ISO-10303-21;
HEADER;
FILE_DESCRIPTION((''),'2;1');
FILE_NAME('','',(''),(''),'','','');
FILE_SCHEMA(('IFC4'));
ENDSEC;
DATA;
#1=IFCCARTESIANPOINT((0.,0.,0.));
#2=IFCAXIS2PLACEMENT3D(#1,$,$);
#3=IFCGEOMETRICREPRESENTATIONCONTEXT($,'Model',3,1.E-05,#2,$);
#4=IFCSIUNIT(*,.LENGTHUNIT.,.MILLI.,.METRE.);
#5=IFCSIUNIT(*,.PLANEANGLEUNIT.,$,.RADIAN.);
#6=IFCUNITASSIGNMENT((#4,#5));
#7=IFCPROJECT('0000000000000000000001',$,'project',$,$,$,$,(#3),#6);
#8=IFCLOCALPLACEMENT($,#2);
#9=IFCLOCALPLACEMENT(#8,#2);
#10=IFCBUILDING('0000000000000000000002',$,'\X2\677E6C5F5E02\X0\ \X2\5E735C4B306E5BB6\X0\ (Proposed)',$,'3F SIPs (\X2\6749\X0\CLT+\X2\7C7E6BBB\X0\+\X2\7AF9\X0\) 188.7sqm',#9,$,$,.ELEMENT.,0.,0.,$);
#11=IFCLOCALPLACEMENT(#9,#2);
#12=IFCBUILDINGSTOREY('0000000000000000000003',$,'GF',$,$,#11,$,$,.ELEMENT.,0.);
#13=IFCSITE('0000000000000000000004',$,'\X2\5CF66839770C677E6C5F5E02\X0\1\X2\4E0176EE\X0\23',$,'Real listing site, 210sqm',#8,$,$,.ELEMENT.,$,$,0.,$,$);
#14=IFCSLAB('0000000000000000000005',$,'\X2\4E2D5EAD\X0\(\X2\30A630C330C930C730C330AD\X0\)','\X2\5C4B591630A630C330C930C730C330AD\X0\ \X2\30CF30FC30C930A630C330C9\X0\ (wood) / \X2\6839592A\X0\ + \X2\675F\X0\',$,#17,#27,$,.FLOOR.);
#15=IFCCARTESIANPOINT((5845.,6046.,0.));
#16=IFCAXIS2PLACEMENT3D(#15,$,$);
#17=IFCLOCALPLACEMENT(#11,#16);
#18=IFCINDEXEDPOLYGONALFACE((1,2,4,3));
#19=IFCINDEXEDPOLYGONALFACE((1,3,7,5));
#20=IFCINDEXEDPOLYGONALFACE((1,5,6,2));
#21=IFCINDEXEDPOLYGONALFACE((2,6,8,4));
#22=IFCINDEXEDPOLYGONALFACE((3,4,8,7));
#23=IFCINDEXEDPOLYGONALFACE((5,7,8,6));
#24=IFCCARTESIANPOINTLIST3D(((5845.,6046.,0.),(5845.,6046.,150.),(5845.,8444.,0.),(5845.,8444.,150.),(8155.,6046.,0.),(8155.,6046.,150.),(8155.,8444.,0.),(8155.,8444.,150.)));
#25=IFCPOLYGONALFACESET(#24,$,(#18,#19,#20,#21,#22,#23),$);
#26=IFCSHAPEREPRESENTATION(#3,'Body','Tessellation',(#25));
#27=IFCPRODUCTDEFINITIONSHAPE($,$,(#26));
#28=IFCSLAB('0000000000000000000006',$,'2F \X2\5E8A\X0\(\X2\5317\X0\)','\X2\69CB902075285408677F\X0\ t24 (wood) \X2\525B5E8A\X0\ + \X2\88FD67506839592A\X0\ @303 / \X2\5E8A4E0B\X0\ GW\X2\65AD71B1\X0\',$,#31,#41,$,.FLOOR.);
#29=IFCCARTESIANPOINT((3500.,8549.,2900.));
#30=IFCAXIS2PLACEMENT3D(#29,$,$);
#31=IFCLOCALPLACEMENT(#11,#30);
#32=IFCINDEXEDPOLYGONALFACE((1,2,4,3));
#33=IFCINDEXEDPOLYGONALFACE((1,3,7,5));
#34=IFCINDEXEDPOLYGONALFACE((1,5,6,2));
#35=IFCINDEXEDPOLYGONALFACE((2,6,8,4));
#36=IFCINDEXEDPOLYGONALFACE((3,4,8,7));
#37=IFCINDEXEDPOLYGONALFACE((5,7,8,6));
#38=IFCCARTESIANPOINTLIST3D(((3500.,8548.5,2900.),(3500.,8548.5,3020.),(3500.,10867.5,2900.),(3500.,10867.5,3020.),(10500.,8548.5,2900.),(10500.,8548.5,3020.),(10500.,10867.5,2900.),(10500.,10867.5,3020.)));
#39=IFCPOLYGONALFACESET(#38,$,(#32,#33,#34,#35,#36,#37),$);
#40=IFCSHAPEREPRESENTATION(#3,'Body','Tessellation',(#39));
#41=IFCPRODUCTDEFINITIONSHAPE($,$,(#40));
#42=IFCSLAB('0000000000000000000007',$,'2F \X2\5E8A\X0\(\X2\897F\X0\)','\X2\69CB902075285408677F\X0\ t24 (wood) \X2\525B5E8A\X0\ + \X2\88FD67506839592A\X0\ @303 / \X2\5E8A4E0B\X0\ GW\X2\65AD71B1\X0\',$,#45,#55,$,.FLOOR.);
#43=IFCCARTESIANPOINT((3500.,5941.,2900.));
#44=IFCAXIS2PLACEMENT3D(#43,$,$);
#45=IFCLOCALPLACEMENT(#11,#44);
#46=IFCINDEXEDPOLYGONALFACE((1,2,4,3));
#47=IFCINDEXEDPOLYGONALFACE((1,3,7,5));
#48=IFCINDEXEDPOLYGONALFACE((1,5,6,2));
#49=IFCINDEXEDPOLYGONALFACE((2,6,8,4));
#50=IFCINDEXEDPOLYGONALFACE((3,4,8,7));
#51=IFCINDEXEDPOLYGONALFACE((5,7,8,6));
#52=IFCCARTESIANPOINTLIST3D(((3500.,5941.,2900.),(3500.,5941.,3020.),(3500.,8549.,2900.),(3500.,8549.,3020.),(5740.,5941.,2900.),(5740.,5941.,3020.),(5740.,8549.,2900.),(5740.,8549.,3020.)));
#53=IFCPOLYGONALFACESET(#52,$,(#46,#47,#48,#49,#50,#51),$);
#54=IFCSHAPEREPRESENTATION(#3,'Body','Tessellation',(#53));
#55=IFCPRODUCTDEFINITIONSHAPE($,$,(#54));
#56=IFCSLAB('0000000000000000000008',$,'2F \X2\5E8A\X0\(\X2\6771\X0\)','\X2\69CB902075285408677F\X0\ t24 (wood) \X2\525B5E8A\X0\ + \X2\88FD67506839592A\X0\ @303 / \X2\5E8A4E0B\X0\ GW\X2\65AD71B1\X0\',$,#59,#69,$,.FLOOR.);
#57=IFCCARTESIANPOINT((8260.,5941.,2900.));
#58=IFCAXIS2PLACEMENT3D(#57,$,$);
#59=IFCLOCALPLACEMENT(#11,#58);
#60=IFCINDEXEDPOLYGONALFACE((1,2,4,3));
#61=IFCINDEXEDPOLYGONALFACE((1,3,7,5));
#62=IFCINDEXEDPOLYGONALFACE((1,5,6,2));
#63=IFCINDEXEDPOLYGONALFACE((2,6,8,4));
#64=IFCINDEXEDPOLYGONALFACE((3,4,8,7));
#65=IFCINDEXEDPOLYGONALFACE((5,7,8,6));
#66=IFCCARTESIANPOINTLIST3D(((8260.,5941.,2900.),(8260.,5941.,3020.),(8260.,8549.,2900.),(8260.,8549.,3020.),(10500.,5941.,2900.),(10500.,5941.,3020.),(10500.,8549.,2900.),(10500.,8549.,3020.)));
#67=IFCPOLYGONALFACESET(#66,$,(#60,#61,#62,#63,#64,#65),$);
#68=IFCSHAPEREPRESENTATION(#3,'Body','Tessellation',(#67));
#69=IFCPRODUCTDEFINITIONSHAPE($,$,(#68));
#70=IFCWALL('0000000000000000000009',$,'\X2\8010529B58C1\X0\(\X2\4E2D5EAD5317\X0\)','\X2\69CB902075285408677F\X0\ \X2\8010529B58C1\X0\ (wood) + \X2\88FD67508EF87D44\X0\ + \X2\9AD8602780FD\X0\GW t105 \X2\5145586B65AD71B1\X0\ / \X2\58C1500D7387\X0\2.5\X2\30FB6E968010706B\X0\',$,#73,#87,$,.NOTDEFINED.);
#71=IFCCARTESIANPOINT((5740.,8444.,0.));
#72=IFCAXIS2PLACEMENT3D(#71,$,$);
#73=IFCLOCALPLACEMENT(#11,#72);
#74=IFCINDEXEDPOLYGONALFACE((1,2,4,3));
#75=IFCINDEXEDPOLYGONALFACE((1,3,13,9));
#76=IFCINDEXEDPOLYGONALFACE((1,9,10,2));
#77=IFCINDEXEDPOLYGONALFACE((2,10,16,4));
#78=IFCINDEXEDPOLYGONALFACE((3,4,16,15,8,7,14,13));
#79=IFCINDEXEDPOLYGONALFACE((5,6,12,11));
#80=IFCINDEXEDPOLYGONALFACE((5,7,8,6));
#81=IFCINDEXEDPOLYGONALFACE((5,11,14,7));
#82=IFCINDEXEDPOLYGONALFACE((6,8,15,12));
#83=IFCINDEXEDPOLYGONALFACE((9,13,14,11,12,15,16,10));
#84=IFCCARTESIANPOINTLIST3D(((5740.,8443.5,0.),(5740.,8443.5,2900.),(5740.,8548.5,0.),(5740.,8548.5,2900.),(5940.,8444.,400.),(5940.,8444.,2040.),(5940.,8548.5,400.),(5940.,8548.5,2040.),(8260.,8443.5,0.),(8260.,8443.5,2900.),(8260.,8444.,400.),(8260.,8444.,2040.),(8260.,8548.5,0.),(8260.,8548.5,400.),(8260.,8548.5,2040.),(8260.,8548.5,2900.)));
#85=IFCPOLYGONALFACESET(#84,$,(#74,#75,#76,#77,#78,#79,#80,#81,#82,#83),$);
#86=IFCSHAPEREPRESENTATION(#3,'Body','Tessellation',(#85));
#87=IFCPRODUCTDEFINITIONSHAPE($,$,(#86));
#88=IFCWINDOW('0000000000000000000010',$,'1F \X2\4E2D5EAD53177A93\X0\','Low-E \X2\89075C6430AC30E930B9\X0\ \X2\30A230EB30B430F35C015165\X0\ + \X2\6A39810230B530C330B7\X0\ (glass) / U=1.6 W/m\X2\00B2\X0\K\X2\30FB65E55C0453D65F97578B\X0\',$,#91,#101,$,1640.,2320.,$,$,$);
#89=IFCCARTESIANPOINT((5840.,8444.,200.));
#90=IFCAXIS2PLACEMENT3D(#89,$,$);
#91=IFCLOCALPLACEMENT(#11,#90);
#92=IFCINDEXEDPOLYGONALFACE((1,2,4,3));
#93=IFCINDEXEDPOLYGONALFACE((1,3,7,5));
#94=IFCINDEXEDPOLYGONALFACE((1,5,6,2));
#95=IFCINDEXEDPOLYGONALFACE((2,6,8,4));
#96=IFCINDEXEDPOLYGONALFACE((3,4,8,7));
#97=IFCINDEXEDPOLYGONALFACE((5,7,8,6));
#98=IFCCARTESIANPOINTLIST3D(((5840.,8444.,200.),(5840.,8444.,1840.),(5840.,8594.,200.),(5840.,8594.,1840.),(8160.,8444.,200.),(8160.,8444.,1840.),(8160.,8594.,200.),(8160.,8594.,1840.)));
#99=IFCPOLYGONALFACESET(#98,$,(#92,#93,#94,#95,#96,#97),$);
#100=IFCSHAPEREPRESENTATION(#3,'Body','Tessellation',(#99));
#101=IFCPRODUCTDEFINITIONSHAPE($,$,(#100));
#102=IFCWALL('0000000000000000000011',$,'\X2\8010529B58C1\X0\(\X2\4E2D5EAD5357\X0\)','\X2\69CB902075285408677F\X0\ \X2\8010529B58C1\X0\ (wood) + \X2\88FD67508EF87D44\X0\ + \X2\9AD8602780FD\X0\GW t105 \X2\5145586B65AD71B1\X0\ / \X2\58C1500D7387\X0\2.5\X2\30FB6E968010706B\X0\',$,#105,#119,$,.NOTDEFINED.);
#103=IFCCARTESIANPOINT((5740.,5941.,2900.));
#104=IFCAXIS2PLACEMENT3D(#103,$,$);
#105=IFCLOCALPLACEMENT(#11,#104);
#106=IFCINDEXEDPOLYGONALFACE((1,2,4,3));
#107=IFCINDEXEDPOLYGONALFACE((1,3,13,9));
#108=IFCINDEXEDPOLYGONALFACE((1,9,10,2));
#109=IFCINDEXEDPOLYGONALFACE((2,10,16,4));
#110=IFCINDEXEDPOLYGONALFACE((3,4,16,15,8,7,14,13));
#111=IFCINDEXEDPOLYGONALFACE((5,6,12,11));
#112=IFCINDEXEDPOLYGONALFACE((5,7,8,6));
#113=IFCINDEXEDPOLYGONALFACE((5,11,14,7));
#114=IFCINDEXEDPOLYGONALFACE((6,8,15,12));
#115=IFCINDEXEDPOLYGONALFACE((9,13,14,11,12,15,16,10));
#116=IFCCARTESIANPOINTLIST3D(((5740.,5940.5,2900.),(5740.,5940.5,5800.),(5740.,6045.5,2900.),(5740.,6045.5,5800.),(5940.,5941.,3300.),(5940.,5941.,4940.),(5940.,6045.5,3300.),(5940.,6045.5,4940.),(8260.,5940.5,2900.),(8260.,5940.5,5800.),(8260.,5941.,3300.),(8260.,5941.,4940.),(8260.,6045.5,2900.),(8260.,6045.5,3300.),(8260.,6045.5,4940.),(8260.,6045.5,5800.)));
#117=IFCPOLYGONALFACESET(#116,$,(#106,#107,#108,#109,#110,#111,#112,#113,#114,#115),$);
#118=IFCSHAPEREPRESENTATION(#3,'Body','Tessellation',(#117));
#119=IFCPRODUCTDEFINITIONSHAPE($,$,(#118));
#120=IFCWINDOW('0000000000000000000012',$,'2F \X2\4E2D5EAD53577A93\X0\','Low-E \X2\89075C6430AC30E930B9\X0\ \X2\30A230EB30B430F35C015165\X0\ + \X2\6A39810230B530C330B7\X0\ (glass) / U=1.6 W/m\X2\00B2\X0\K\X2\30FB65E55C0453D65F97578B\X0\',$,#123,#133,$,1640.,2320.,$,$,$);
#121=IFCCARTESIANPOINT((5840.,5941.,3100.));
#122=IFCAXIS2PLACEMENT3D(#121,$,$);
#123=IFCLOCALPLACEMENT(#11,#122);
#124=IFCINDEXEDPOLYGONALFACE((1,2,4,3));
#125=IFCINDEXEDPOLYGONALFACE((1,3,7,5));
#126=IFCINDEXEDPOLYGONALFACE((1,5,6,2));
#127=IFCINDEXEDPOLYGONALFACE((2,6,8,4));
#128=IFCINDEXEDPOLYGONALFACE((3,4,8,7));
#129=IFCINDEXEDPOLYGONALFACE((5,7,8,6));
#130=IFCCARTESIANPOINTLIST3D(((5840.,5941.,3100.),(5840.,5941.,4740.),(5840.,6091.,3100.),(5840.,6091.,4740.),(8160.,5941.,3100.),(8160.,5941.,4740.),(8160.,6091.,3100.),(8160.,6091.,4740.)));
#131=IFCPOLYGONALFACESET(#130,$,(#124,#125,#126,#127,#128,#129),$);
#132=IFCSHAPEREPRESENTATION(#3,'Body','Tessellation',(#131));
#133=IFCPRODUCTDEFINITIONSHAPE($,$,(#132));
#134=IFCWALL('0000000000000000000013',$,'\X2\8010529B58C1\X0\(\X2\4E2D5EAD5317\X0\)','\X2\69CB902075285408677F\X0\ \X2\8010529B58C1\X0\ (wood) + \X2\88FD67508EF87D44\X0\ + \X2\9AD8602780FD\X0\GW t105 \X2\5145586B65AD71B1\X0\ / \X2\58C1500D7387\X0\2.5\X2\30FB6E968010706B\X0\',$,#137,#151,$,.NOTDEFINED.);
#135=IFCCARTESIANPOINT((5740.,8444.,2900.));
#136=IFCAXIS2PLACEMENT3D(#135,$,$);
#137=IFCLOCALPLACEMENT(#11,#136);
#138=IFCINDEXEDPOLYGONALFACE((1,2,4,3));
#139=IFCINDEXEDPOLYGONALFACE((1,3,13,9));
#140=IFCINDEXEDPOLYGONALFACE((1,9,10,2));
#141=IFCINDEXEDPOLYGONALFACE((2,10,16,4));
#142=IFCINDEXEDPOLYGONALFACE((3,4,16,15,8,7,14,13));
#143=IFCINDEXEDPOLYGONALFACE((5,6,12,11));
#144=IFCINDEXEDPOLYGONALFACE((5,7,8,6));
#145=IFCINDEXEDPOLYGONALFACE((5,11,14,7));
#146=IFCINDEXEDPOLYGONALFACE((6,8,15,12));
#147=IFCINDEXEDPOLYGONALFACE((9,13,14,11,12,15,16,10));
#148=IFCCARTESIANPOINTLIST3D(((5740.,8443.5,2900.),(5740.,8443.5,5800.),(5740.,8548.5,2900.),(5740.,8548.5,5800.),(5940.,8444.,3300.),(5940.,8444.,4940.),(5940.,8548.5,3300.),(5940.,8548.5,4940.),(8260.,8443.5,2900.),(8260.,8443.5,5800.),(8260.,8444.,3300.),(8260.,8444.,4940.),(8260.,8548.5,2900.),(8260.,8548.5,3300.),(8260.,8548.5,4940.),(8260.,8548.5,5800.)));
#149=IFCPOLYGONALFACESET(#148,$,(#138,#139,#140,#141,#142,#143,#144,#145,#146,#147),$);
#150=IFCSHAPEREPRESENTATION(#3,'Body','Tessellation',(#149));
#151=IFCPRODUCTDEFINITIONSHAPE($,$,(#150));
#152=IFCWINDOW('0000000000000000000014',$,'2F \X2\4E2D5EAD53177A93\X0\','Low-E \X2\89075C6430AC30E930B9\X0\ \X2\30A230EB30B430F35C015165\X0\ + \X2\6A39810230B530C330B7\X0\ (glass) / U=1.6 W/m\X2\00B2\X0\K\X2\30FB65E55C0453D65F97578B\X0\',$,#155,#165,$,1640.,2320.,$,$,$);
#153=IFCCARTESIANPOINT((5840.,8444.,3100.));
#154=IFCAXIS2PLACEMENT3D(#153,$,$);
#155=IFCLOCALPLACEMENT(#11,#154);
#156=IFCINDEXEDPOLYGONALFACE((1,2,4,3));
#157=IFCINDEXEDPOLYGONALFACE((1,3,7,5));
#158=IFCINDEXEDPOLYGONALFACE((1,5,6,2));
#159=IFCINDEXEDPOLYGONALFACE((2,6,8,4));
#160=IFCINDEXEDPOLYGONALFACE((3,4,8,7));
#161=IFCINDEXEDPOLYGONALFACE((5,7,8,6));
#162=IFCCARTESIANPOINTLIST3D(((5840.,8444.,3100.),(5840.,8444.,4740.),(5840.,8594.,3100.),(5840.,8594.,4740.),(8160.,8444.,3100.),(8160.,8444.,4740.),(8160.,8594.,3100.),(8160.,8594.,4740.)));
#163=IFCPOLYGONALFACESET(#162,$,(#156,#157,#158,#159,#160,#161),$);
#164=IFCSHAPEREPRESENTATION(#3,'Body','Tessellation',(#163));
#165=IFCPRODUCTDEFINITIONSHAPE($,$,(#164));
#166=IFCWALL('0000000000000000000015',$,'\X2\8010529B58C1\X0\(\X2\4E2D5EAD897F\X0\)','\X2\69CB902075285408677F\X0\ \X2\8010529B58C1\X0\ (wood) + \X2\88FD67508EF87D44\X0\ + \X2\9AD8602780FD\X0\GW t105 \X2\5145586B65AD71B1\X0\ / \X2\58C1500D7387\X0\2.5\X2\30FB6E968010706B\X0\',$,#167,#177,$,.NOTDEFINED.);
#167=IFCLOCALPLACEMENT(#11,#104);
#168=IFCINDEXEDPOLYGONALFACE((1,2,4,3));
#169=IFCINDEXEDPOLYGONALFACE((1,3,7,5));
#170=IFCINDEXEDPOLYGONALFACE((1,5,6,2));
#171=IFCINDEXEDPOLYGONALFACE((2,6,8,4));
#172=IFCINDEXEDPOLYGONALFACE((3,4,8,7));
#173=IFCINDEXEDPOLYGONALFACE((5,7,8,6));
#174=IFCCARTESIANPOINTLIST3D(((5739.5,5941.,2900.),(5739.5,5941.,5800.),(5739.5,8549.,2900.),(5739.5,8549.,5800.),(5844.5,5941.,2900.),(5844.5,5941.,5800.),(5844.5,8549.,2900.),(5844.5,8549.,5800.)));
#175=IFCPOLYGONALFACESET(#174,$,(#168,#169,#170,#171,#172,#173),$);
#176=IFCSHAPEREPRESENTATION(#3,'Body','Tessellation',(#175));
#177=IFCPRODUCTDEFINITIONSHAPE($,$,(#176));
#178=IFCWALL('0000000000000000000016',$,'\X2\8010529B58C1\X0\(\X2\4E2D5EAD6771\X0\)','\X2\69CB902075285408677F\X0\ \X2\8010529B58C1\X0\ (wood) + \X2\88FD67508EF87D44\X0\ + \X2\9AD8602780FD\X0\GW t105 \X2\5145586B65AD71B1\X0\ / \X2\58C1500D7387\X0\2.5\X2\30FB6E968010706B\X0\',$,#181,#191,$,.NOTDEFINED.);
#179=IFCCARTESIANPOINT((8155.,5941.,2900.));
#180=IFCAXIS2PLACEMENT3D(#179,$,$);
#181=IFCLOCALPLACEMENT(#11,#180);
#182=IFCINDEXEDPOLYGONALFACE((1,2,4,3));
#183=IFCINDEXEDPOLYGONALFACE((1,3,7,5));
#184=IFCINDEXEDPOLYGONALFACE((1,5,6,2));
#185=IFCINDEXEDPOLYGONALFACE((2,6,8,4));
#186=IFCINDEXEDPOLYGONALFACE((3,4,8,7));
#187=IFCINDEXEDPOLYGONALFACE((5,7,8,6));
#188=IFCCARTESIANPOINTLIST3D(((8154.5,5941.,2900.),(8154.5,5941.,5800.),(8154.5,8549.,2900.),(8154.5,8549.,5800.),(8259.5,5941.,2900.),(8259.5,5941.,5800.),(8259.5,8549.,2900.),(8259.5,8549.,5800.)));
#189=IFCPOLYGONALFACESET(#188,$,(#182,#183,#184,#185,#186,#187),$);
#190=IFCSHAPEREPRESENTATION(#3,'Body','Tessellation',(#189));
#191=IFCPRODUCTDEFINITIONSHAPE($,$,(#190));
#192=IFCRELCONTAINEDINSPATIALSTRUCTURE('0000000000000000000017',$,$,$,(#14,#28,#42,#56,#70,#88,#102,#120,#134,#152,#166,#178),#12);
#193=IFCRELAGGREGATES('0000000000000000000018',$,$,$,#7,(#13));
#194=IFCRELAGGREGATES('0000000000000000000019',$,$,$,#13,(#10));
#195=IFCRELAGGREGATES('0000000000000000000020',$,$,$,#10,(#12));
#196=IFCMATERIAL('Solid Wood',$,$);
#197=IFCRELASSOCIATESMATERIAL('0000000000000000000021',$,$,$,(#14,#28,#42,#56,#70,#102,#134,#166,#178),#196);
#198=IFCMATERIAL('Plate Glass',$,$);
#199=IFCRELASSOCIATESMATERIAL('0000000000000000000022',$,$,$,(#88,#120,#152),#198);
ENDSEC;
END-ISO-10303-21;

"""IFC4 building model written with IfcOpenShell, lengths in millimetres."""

from ifc_helpers import new_model, si_unit, frame, frame_2d, origin, place, context, project, spatial, rectangle, extrude, material, element, fill, save


model = new_model("IFC4")

# Units and contexts
model_context = context("Model", 3, precision=1e-05, world=origin())
ifc_project = project(units=[si_unit("LENGTHUNIT", "METRE", prefix="MILLI"), si_unit("PLANEANGLEUNIT", "RADIAN")], contexts=[model_context])

# Site, building, storey
site_placement = place(None, origin())
site = spatial("IfcSite", under=ifc_project, at=site_placement, Name="島根県松江市1丁目23", ObjectType="Real listing site, 210sqm", CompositionType="ELEMENT", RefElevation=0.0)
building_placement = place(site_placement, origin())
building = spatial("IfcBuilding", under=site, at=building_placement, Name="松江市 平屋の家 (Proposed)", ObjectType="3F SIPs (杉CLT+籾殻+竹) 188.7sqm", CompositionType="ELEMENT", ElevationOfRefHeight=0.0, ElevationOfTerrain=0.0)
storey_placement = place(building_placement, origin())
storey = spatial("IfcBuildingStorey", under=building, at=storey_placement, Name="GF", CompositionType="ELEMENT", Elevation=0.0)

# Slabs
ifc_material_1 = material(Name="Solid Wood")
slab_1_placement = place(storey_placement, frame((5845.0, 6046.0, 0.0)))
element("IfcSlab", 1, at=slab_1_placement, inside=storey, material=ifc_material_1, Name="中庭(ウッドデッキ)", Description="屋外ウッドデッキ ハードウッド (wood) / 根太 + 束", PredefinedType="FLOOR", context=model_context, shape_type="SweptSolid", body=[
    extrude(rectangle(XDim=2310.0, YDim=2398.0, at=frame_2d((1155.0, 1199.0))), frame((5845.0, 6046.0, 0.0)), (0.0, 0.0, 1.0), 150.0),
])
slab_2_placement = place(storey_placement, frame((3500.0, 8549.0, 2900.0)))
element("IfcSlab", 2, at=slab_2_placement, inside=storey, material=ifc_material_1, Name="2F 床(北)", Description="構造用合板 t24 (wood) 剛床 + 製材根太 @303 / 床下 GW断熱", PredefinedType="FLOOR", context=model_context, shape_type="SweptSolid", body=[
    extrude(rectangle(XDim=7000.0, YDim=2319.0, at=frame_2d((3500.0, 1159.0))), frame((3500.0, 8549.0, 2900.0)), (0.0, 0.0, 1.0), 120.0),
])
slab_3_placement = place(storey_placement, frame((3500.0, 5941.0, 2900.0)))
element("IfcSlab", 3, at=slab_3_placement, inside=storey, material=ifc_material_1, Name="2F 床(西)", Description="構造用合板 t24 (wood) 剛床 + 製材根太 @303 / 床下 GW断熱", PredefinedType="FLOOR", context=model_context, shape_type="SweptSolid", body=[
    extrude(rectangle(XDim=2240.0, YDim=2608.0, at=frame_2d((1120.0, 1304.0))), frame((3500.0, 5941.0, 2900.0)), (0.0, 0.0, 1.0), 120.0),
])
slab_4_placement = place(storey_placement, frame((8260.0, 5941.0, 2900.0)))
element("IfcSlab", 4, at=slab_4_placement, inside=storey, material=ifc_material_1, Name="2F 床(東)", Description="構造用合板 t24 (wood) 剛床 + 製材根太 @303 / 床下 GW断熱", PredefinedType="FLOOR", context=model_context, shape_type="SweptSolid", body=[
    extrude(rectangle(XDim=2240.0, YDim=2608.0, at=frame_2d((1120.0, 1304.0))), frame((8260.0, 5941.0, 2900.0)), (0.0, 0.0, 1.0), 120.0),
])

# Wall, opening, window
wall_1_placement = place(storey_placement, frame((5740.0, 8444.0, 0.0)))
wall_1 = element("IfcWall", 5, at=wall_1_placement, inside=storey, material=ifc_material_1, Name="耐力壁(中庭北)", Description="構造用合板 耐力壁 (wood) + 製材軸組 + 高性能GW t105 充填断熱 / 壁倍率2.5・準耐火", PredefinedType="NOTDEFINED", context=model_context, shape_type="SweptSolid", body=[
    extrude(rectangle(XDim=2520.0, YDim=105.0, at=frame_2d((1260.0, 52.0))), frame((5740.0, 8444.0, 0.0)), (0.0, 0.0, 1.0), 2900.0),
])
opening_1_placement = place(storey_placement, frame((5840.0, 8444.0, 200.0)))
opening_1 = element("IfcOpeningElement", 6, at=opening_1_placement, cuts=wall_1, PredefinedType="NOTDEFINED", context=model_context, shape_type="SweptSolid", body=[
    extrude(rectangle(XDim=2320.0, YDim=150.0, at=frame_2d((1160.0, 75.0))), frame((5840.0, 8444.0, 200.0)), (0.0, 0.0, 1.0), 1640.0),
])
ifc_material_2 = material(Name="Plate Glass")
window_1_placement = place(storey_placement, frame((5840.0, 8444.0, 200.0)))
window_1 = element("IfcWindow", 7, at=window_1_placement, inside=storey, material=ifc_material_2, Name="1F 中庭北窓", Description="Low-E 複層ガラス アルゴン封入 + 樹脂サッシ (glass) / U=1.6 W/m²K・日射取得型", OverallHeight=1640.0, OverallWidth=2320.0, context=model_context, shape_type="SweptSolid", body=[
    extrude(rectangle(XDim=2320.0, YDim=150.0, at=frame_2d((1160.0, 75.0))), frame((5840.0, 8444.0, 200.0)), (0.0, 0.0, 1.0), 1640.0),
])
fill(opening_1, window_1)

# Walls, openings, windows
wall_2_placement = place(storey_placement, frame((5740.0, 5941.0, 2900.0)))
wall_2 = element("IfcWall", 8, at=wall_2_placement, inside=storey, material=ifc_material_1, Name="耐力壁(中庭南)", Description="構造用合板 耐力壁 (wood) + 製材軸組 + 高性能GW t105 充填断熱 / 壁倍率2.5・準耐火", PredefinedType="NOTDEFINED", context=model_context, shape_type="SweptSolid", body=[
    extrude(rectangle(XDim=2520.0, YDim=105.0, at=frame_2d((1260.0, 52.0))), frame((5740.0, 5941.0, 2900.0)), (0.0, 0.0, 1.0), 2900.0),
])
opening_2_placement = place(storey_placement, frame((5840.0, 5941.0, 3100.0)))
opening_2 = element("IfcOpeningElement", 9, at=opening_2_placement, cuts=wall_2, PredefinedType="NOTDEFINED", context=model_context, shape_type="SweptSolid", body=[
    extrude(rectangle(XDim=2320.0, YDim=150.0, at=frame_2d((1160.0, 75.0))), frame((5840.0, 5941.0, 3100.0)), (0.0, 0.0, 1.0), 1640.0),
])
window_2_placement = place(storey_placement, frame((5840.0, 5941.0, 3100.0)))
window_2 = element("IfcWindow", 10, at=window_2_placement, inside=storey, material=ifc_material_2, Name="2F 中庭南窓", Description="Low-E 複層ガラス アルゴン封入 + 樹脂サッシ (glass) / U=1.6 W/m²K・日射取得型", OverallHeight=1640.0, OverallWidth=2320.0, context=model_context, shape_type="SweptSolid", body=[
    extrude(rectangle(XDim=2320.0, YDim=150.0, at=frame_2d((1160.0, 75.0))), frame((5840.0, 5941.0, 3100.0)), (0.0, 0.0, 1.0), 1640.0),
])
fill(opening_2, window_2)
wall_3_placement = place(storey_placement, frame((5740.0, 8444.0, 2900.0)))
wall_3 = element("IfcWall", 11, at=wall_3_placement, inside=storey, material=ifc_material_1, Name="耐力壁(中庭北)", Description="構造用合板 耐力壁 (wood) + 製材軸組 + 高性能GW t105 充填断熱 / 壁倍率2.5・準耐火", PredefinedType="NOTDEFINED", context=model_context, shape_type="SweptSolid", body=[
    extrude(rectangle(XDim=2520.0, YDim=105.0, at=frame_2d((1260.0, 52.0))), frame((5740.0, 8444.0, 2900.0)), (0.0, 0.0, 1.0), 2900.0),
])
opening_3_placement = place(storey_placement, frame((5840.0, 8444.0, 3100.0)))
opening_3 = element("IfcOpeningElement", 12, at=opening_3_placement, cuts=wall_3, PredefinedType="NOTDEFINED", context=model_context, shape_type="SweptSolid", body=[
    extrude(rectangle(XDim=2320.0, YDim=150.0, at=frame_2d((1160.0, 75.0))), frame((5840.0, 8444.0, 3100.0)), (0.0, 0.0, 1.0), 1640.0),
])
window_3_placement = place(storey_placement, frame((5840.0, 8444.0, 3100.0)))
window_3 = element("IfcWindow", 13, at=window_3_placement, inside=storey, material=ifc_material_2, Name="2F 中庭北窓", Description="Low-E 複層ガラス アルゴン封入 + 樹脂サッシ (glass) / U=1.6 W/m²K・日射取得型", OverallHeight=1640.0, OverallWidth=2320.0, context=model_context, shape_type="SweptSolid", body=[
    extrude(rectangle(XDim=2320.0, YDim=150.0, at=frame_2d((1160.0, 75.0))), frame((5840.0, 8444.0, 3100.0)), (0.0, 0.0, 1.0), 1640.0),
])
fill(opening_3, window_3)

# Walls
wall_4_placement = place(storey_placement, frame((5740.0, 5941.0, 2900.0)))
element("IfcWall", 14, at=wall_4_placement, inside=storey, material=ifc_material_1, Name="耐力壁(中庭西)", Description="構造用合板 耐力壁 (wood) + 製材軸組 + 高性能GW t105 充填断熱 / 壁倍率2.5・準耐火", PredefinedType="NOTDEFINED", context=model_context, shape_type="SweptSolid", body=[
    extrude(rectangle(XDim=105.0, YDim=2608.0, at=frame_2d((52.0, 1304.0))), frame((5740.0, 5941.0, 2900.0)), (0.0, 0.0, 1.0), 2900.0),
])
wall_5_placement = place(storey_placement, frame((8155.0, 5941.0, 2900.0)))
element("IfcWall", 15, at=wall_5_placement, inside=storey, material=ifc_material_1, Name="耐力壁(中庭東)", Description="構造用合板 耐力壁 (wood) + 製材軸組 + 高性能GW t105 充填断熱 / 壁倍率2.5・準耐火", PredefinedType="NOTDEFINED", context=model_context, shape_type="SweptSolid", body=[
    extrude(rectangle(XDim=105.0, YDim=2608.0, at=frame_2d((52.0, 1304.0))), frame((8155.0, 5941.0, 2900.0)), (0.0, 0.0, 1.0), 2900.0),
])

save(model, "model.ifc")
